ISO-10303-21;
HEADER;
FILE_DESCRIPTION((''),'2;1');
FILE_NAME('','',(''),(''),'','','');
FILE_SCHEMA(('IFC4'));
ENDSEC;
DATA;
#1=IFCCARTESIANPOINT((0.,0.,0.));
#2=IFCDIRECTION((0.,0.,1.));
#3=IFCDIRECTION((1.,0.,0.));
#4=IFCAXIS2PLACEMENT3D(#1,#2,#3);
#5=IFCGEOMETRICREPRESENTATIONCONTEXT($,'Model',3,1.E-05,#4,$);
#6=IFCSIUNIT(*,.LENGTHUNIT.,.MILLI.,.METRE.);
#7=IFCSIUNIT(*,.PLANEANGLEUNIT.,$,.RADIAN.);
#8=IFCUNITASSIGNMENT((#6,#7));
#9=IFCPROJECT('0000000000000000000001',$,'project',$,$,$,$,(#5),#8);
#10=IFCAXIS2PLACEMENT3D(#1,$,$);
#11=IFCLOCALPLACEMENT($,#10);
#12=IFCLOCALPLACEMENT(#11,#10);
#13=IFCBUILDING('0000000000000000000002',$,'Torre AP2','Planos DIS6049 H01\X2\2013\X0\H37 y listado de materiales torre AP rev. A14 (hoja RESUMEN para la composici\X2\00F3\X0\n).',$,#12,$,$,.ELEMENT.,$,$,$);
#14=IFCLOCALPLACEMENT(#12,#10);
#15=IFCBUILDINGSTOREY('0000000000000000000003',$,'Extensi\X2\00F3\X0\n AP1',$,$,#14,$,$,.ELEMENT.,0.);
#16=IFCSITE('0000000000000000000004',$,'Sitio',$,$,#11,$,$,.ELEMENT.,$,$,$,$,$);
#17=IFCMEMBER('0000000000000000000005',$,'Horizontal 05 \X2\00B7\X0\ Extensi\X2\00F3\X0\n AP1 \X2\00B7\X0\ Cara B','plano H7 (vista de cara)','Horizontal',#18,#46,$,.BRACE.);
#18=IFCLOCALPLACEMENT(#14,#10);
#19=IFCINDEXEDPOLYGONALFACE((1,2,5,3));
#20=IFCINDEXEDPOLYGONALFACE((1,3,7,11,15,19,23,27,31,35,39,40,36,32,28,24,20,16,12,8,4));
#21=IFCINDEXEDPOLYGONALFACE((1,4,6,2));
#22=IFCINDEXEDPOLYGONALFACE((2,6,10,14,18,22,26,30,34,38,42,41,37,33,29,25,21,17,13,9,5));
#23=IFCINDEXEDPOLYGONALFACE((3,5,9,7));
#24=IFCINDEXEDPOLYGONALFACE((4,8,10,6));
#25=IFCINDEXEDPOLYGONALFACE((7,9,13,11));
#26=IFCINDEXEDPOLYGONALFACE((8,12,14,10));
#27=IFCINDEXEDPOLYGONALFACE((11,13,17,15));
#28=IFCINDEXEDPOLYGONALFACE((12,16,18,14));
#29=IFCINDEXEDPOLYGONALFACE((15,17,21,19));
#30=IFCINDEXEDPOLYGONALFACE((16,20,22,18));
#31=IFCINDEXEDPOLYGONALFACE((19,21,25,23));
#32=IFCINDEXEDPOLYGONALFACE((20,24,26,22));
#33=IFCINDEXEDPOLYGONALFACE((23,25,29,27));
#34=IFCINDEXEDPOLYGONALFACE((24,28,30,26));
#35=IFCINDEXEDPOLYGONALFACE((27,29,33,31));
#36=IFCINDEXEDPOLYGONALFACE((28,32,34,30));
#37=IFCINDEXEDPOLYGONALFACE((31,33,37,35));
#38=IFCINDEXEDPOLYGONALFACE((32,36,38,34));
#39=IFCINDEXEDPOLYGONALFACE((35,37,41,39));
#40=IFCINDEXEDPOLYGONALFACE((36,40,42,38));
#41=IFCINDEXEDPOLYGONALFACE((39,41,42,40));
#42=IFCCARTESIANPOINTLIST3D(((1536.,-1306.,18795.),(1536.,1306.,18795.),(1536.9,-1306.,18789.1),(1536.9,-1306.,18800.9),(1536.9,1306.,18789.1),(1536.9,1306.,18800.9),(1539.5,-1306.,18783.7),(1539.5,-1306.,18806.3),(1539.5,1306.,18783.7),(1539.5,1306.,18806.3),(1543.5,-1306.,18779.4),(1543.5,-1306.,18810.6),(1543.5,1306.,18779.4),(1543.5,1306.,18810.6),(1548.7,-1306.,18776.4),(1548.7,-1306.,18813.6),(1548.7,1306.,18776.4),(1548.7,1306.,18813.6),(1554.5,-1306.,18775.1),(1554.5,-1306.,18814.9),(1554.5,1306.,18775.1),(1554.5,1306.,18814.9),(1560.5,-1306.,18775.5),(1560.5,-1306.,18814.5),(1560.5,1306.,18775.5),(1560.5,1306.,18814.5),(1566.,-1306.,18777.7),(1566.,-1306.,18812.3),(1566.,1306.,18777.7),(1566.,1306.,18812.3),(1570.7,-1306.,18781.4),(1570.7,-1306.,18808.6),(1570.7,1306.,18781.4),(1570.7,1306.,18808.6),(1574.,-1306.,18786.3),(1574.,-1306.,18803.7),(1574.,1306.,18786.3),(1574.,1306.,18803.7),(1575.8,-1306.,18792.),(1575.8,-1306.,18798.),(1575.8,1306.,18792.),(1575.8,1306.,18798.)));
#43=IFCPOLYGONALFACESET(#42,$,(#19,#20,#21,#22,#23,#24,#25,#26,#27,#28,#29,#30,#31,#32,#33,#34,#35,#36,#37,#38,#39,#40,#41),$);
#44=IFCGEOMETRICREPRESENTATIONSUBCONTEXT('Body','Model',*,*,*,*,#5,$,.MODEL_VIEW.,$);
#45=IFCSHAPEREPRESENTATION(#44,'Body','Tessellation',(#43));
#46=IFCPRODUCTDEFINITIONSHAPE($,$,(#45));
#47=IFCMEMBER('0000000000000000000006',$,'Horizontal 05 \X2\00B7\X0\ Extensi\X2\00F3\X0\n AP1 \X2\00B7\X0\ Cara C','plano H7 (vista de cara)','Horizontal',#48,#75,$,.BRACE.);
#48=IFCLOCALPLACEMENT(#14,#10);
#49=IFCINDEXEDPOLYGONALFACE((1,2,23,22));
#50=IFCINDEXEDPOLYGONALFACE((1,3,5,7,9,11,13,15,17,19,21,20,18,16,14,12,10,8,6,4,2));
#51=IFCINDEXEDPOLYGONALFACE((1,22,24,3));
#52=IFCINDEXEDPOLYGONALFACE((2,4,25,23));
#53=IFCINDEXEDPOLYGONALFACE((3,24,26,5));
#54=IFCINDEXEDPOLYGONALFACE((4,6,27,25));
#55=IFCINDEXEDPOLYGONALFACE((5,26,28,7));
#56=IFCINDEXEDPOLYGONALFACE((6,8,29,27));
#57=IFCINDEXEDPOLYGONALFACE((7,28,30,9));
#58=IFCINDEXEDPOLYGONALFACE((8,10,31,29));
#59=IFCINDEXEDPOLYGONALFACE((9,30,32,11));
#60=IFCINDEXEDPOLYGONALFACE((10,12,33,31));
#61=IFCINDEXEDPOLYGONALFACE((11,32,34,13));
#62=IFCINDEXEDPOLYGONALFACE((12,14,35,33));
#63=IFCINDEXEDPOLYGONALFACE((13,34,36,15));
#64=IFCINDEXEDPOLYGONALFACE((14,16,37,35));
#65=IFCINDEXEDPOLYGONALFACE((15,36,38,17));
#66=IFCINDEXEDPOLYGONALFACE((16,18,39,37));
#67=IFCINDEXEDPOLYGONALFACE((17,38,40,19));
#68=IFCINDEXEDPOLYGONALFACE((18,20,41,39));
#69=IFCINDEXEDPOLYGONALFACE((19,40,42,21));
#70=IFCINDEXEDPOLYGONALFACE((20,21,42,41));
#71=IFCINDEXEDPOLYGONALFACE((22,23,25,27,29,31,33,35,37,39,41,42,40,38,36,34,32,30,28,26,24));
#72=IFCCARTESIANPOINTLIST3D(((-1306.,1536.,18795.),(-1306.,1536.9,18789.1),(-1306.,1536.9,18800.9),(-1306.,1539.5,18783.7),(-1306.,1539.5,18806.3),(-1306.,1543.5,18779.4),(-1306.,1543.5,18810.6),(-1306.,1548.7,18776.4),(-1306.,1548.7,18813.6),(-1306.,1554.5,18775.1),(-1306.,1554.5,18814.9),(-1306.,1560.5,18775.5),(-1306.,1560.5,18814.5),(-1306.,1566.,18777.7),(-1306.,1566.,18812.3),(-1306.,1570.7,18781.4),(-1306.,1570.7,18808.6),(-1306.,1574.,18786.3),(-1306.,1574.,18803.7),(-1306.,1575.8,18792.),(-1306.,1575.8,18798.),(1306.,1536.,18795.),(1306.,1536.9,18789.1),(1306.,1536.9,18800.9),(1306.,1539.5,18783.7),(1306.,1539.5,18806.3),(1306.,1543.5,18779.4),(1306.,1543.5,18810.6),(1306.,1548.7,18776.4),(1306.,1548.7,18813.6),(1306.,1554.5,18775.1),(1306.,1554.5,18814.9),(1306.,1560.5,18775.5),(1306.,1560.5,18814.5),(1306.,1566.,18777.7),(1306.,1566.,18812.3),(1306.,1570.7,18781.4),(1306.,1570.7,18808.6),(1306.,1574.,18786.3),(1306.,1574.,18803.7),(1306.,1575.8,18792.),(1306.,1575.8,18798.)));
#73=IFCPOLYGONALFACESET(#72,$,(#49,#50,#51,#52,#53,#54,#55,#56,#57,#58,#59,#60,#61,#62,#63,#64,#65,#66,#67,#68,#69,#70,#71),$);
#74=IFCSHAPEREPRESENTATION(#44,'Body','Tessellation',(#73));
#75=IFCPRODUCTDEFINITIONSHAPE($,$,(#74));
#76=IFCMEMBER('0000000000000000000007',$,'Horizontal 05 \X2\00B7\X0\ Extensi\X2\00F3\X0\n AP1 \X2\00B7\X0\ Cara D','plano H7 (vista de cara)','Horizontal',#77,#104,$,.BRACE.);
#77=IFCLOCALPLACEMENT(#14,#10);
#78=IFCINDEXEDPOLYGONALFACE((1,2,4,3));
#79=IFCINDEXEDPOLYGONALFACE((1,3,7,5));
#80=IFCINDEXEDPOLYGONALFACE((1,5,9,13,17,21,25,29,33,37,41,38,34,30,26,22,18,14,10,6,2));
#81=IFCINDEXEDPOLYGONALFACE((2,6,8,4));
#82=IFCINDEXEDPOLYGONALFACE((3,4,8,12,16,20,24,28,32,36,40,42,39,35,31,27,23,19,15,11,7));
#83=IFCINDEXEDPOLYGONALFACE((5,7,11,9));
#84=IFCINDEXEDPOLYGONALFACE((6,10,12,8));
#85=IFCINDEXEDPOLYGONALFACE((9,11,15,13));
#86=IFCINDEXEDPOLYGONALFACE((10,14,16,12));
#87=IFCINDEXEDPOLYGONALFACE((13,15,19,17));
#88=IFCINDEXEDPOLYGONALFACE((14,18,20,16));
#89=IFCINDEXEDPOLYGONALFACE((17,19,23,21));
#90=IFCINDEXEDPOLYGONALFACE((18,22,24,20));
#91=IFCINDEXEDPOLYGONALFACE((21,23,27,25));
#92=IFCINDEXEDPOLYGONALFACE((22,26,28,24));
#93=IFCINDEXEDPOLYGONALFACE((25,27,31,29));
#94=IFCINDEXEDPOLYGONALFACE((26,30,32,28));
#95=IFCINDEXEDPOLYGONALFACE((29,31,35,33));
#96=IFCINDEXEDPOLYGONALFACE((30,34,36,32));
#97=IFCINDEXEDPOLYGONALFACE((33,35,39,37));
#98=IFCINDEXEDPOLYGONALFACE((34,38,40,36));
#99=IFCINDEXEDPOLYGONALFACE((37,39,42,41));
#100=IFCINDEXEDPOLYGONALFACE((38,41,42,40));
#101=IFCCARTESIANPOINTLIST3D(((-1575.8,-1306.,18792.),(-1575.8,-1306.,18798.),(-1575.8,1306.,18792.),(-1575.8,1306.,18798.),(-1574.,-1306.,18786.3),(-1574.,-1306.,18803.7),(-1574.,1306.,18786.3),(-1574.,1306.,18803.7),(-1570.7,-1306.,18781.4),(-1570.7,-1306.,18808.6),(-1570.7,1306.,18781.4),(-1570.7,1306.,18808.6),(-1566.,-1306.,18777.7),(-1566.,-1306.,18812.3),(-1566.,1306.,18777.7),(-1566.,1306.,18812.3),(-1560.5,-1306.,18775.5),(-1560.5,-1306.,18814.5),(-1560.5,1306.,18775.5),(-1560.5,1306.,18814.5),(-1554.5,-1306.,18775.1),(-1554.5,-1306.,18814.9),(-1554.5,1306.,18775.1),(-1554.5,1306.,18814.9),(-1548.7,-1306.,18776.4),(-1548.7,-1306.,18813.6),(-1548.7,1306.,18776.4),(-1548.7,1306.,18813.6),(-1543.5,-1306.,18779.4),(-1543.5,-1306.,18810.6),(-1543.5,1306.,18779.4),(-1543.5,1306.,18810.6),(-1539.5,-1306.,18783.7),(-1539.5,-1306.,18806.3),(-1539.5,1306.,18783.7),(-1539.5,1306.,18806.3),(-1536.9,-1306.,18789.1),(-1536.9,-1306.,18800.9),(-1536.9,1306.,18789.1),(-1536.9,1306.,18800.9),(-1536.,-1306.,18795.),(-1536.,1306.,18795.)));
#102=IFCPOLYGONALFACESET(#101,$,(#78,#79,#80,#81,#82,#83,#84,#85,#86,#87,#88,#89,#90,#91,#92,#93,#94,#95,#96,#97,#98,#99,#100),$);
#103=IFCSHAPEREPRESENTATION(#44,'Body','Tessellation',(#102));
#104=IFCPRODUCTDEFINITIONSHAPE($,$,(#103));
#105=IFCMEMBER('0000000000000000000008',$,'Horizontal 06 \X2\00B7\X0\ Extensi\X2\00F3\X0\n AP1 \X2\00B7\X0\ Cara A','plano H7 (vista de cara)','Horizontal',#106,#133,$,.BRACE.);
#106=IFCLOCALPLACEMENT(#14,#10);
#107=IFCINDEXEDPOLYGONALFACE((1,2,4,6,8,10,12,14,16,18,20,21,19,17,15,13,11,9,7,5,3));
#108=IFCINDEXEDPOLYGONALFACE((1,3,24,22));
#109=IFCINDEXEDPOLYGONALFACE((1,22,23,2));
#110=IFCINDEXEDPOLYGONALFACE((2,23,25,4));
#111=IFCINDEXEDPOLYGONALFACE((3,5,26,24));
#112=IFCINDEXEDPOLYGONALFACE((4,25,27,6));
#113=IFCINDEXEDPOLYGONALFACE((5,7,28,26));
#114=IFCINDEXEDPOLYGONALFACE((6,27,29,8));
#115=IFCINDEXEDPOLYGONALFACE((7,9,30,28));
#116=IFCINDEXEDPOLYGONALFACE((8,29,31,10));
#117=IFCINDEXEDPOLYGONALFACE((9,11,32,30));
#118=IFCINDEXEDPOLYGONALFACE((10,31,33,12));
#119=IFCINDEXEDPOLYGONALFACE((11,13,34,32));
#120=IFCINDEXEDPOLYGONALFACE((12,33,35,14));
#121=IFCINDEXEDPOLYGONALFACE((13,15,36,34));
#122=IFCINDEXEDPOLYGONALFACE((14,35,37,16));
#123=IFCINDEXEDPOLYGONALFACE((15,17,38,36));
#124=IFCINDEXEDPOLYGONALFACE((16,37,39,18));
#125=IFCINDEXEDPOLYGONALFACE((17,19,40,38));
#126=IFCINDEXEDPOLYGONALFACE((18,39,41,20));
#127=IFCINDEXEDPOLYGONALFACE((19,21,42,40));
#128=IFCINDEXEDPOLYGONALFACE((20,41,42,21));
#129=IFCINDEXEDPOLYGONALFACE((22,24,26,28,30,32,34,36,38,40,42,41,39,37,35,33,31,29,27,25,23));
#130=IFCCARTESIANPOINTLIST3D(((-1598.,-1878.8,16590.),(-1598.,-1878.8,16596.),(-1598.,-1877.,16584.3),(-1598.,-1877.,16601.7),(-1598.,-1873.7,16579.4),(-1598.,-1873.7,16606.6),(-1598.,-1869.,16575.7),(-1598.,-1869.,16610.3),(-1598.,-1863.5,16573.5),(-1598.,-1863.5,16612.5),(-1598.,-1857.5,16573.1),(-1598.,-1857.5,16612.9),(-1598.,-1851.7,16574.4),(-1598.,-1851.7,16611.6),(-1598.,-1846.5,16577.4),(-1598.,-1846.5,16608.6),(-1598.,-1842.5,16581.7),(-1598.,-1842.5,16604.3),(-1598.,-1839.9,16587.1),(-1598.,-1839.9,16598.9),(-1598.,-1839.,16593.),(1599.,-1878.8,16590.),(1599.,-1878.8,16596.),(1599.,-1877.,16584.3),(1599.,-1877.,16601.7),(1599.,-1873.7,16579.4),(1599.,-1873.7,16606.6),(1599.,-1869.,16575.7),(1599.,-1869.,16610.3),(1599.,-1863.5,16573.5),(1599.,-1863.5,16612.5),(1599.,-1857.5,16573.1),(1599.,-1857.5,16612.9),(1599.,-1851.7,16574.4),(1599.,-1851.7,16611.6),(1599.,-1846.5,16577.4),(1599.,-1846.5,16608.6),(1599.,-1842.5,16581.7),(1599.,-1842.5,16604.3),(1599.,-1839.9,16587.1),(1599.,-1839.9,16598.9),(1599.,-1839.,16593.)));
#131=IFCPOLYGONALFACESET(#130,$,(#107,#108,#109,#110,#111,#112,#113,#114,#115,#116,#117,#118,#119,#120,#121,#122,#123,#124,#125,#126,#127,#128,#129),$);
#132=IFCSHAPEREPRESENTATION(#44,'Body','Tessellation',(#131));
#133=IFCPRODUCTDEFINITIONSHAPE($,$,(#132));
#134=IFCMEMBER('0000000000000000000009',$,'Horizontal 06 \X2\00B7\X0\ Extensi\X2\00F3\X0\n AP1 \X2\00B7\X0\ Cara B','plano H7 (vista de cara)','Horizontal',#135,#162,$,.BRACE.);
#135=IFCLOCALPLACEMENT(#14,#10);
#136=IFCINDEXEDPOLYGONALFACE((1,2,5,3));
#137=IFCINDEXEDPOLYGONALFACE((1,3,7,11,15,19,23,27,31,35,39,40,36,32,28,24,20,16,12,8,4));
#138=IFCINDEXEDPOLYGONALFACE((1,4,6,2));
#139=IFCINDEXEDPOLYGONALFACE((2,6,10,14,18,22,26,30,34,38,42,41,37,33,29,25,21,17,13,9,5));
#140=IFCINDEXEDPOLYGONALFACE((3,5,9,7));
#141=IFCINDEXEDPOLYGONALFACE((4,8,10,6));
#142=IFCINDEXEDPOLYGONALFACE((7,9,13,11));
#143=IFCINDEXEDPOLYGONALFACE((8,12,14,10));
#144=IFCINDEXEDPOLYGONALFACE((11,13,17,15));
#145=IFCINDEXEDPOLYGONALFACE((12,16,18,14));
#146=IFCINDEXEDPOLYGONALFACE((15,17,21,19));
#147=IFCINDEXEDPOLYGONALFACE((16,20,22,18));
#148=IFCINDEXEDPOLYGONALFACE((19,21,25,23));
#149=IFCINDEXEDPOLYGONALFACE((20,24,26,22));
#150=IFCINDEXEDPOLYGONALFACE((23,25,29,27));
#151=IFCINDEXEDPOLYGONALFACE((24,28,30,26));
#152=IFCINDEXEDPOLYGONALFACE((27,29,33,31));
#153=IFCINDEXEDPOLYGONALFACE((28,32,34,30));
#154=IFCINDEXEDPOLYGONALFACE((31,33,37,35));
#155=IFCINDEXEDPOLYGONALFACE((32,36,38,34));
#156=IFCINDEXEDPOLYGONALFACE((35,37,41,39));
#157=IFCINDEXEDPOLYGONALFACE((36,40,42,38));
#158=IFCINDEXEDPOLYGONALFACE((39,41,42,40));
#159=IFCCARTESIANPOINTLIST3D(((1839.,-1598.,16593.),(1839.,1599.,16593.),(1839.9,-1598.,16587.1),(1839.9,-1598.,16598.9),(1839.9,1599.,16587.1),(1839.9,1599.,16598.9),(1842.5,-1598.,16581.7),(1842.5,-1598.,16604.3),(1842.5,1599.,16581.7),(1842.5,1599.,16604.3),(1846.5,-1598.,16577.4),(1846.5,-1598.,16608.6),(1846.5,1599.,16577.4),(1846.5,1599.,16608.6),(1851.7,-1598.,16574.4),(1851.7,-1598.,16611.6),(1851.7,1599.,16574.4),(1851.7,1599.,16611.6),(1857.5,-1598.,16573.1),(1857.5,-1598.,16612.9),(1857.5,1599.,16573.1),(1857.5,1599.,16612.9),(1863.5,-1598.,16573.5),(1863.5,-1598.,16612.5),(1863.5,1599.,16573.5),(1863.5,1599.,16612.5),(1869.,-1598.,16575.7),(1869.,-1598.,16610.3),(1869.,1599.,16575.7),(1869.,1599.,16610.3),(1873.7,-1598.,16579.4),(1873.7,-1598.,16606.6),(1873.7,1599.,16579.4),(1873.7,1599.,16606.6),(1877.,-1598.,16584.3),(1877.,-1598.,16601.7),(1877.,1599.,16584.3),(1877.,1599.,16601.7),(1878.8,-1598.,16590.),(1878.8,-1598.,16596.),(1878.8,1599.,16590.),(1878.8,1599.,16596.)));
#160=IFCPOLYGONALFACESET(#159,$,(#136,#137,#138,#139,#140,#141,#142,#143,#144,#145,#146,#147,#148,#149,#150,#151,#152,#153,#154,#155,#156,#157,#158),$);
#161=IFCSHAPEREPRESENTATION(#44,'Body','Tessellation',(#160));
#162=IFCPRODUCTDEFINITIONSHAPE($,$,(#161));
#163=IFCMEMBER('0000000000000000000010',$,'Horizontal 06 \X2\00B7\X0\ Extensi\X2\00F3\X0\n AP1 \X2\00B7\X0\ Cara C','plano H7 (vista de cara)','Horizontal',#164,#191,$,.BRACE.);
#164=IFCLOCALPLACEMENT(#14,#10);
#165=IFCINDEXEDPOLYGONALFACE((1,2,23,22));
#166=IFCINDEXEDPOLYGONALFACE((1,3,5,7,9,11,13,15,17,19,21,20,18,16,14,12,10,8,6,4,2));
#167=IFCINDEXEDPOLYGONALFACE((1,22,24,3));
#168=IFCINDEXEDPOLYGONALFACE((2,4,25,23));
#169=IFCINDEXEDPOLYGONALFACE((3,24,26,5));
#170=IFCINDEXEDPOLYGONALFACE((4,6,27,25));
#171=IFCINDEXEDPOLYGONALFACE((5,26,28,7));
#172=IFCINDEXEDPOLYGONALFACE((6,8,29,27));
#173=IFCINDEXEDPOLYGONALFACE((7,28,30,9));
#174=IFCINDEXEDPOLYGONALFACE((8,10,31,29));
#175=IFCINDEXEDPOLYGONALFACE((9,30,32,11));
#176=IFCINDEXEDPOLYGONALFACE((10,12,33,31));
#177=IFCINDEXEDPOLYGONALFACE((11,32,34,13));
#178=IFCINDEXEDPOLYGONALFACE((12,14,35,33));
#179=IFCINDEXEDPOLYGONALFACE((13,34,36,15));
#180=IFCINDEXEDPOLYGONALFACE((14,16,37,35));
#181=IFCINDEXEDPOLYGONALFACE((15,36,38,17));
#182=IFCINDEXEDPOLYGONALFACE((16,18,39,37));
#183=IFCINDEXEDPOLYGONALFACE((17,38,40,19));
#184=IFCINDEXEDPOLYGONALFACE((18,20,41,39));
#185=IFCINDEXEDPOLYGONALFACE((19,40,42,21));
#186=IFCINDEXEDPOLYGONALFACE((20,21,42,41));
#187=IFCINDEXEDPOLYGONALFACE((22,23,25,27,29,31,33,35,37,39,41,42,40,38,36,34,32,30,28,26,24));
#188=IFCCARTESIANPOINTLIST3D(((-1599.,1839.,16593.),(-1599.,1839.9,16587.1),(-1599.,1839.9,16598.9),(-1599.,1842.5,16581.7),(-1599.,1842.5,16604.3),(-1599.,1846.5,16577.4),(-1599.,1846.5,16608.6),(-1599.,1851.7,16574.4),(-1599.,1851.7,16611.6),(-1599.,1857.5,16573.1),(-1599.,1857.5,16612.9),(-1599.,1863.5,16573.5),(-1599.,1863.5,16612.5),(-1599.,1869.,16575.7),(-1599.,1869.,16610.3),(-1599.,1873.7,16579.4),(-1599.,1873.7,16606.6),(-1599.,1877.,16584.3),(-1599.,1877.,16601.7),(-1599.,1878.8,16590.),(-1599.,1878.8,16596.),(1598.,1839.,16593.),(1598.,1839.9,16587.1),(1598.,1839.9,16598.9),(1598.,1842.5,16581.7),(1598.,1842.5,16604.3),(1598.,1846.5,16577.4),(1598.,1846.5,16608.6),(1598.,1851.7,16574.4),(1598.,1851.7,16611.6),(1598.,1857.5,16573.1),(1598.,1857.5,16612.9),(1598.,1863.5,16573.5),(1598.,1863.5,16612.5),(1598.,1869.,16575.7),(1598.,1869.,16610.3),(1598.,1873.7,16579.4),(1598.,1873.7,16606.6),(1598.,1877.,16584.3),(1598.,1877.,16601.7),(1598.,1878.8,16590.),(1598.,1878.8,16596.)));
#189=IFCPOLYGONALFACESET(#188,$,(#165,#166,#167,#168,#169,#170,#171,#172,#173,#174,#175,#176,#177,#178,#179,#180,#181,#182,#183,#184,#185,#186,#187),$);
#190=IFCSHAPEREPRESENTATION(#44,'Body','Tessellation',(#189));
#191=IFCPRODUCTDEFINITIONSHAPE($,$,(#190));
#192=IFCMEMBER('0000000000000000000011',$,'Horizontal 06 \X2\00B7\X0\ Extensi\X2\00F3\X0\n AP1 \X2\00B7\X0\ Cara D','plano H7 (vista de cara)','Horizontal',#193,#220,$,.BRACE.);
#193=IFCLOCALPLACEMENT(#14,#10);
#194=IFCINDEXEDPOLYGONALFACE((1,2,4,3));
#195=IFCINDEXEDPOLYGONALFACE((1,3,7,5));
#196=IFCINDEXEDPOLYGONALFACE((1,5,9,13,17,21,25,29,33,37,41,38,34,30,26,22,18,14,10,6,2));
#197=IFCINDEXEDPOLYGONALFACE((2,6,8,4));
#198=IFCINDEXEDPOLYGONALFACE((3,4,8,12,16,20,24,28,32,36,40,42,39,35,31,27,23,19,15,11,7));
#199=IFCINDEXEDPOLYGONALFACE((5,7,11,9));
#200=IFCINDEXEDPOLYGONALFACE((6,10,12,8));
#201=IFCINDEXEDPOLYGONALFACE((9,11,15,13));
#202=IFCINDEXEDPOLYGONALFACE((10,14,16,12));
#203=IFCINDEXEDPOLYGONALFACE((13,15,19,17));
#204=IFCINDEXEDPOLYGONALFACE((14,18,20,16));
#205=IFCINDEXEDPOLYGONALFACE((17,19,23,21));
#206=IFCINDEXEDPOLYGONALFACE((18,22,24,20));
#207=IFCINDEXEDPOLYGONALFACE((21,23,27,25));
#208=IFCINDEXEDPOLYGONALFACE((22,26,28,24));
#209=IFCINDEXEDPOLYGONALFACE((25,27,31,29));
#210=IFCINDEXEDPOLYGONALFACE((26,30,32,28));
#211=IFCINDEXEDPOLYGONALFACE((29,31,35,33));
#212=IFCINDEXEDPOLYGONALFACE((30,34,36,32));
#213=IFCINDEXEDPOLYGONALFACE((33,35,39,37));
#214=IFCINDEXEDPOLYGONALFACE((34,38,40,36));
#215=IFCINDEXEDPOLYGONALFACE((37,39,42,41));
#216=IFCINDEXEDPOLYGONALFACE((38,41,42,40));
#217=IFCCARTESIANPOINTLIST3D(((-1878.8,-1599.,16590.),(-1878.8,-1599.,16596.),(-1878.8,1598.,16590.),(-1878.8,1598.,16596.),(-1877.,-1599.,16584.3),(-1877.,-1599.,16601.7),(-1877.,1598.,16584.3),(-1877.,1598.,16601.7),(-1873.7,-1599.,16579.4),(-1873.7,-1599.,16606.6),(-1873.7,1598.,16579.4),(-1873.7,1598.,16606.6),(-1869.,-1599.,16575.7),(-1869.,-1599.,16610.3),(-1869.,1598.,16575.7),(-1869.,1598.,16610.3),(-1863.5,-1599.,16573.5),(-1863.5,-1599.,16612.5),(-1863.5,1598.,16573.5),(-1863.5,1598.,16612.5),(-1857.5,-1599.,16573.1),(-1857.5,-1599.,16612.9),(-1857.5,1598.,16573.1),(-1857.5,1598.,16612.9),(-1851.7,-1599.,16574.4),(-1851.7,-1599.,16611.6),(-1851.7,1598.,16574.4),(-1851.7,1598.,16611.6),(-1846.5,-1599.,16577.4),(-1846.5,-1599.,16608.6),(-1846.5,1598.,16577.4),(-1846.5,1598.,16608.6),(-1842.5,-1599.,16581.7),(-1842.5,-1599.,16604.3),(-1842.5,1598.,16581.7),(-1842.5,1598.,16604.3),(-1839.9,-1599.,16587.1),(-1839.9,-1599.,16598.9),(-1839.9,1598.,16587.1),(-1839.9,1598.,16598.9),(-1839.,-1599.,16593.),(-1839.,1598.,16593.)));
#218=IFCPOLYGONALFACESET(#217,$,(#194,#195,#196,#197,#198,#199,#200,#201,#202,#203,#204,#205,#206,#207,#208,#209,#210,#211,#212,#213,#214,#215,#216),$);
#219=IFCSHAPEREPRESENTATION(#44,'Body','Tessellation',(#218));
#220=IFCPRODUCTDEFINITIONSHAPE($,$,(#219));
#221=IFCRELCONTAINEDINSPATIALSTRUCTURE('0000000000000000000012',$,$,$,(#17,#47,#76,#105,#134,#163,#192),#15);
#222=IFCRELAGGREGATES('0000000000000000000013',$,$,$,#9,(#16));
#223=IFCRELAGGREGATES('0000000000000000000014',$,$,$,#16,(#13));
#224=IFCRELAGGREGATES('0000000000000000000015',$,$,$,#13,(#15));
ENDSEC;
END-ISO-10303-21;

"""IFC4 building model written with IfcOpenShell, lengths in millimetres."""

from ifc_helpers import new_model, si_unit, frame, origin, origin_with_axes, place, context, subcontext, project, spatial, circle, extrude, element, save


model = new_model("IFC4")

# Units and contexts
model_context = context("Model", 3, precision=1e-05, world=origin_with_axes())
body_context = subcontext(model_context, "Body", "Model", "MODEL_VIEW")
ifc_project = project(units=[si_unit("LENGTHUNIT", "METRE", prefix="MILLI"), si_unit("PLANEANGLEUNIT", "RADIAN")], contexts=[model_context])

# Site, building, storey
site_placement = place(None, origin())
site = spatial("IfcSite", under=ifc_project, at=site_placement, Name="Sitio", CompositionType="ELEMENT")
building_placement = place(site_placement, origin())
building = spatial("IfcBuilding", under=site, at=building_placement, Name="Torre AP2", Description="Planos DIS6049 H01–H37 y listado de materiales torre AP rev. A14 (hoja RESUMEN para la composición).", CompositionType="ELEMENT")
storey_placement = place(building_placement, origin())
storey = spatial("IfcBuildingStorey", under=building, at=storey_placement, Name="Extensión AP1", CompositionType="ELEMENT", Elevation=0.0)

# Members
for number, where, z_axis, x_axis, name in (
    (1, (1556.0, 1306.0, 18795.0), (0.0, -1.0, 0.0), (-1.0, 0.0, 0.0), "Horizontal 05 · Extensión AP1 · Cara B"),
    (2, (-1306.0, 1556.0, 18795.0), (1.0, 0.0, 0.0), (0.0, -1.0, 0.0), "Horizontal 05 · Extensión AP1 · Cara C"),
    (3, (-1556.0, -1306.0, 18795.0), (0.0, 1.0, 0.0), (1.0, 0.0, 0.0), "Horizontal 05 · Extensión AP1 · Cara D"),
):
    element("IfcMember", number, at=place(storey_placement, frame(where, z_axis=z_axis, x_axis=x_axis)), inside=storey, Name=name, Description="plano H7 (vista de cara)", ObjectType="Horizontal", PredefinedType="BRACE", context=body_context, shape_type="SweptSolid", body=[
        extrude(circle(Radius=20.0), None, (0.0, 0.0, 1.0), 2612.0),
    ])
for number, where, z_axis, x_axis, name in (
    (4, (1599.0, -1859.0, 16593.0), (-1.0, 0.0, 0.0), (0.0, 1.0, 0.0), "Horizontal 06 · Extensión AP1 · Cara A"),
    (5, (1859.0, 1599.0, 16593.0), (0.0, -1.0, 0.0), (-1.0, 0.0, 0.0), "Horizontal 06 · Extensión AP1 · Cara B"),
    (6, (-1599.0, 1859.0, 16593.0), (1.0, 0.0, 0.0), (0.0, -1.0, 0.0), "Horizontal 06 · Extensión AP1 · Cara C"),
    (7, (-1859.0, -1599.0, 16593.0), (0.0, 1.0, 0.0), (1.0, 0.0, 0.0), "Horizontal 06 · Extensión AP1 · Cara D"),
):
    element("IfcMember", number, at=place(storey_placement, frame(where, z_axis=z_axis, x_axis=x_axis)), inside=storey, Name=name, Description="plano H7 (vista de cara)", ObjectType="Horizontal", PredefinedType="BRACE", context=body_context, shape_type="SweptSolid", body=[
        extrude(circle(Radius=20.0), None, (0.0, 0.0, 1.0), 3197.0),
    ])

save(model, "model.ifc")
